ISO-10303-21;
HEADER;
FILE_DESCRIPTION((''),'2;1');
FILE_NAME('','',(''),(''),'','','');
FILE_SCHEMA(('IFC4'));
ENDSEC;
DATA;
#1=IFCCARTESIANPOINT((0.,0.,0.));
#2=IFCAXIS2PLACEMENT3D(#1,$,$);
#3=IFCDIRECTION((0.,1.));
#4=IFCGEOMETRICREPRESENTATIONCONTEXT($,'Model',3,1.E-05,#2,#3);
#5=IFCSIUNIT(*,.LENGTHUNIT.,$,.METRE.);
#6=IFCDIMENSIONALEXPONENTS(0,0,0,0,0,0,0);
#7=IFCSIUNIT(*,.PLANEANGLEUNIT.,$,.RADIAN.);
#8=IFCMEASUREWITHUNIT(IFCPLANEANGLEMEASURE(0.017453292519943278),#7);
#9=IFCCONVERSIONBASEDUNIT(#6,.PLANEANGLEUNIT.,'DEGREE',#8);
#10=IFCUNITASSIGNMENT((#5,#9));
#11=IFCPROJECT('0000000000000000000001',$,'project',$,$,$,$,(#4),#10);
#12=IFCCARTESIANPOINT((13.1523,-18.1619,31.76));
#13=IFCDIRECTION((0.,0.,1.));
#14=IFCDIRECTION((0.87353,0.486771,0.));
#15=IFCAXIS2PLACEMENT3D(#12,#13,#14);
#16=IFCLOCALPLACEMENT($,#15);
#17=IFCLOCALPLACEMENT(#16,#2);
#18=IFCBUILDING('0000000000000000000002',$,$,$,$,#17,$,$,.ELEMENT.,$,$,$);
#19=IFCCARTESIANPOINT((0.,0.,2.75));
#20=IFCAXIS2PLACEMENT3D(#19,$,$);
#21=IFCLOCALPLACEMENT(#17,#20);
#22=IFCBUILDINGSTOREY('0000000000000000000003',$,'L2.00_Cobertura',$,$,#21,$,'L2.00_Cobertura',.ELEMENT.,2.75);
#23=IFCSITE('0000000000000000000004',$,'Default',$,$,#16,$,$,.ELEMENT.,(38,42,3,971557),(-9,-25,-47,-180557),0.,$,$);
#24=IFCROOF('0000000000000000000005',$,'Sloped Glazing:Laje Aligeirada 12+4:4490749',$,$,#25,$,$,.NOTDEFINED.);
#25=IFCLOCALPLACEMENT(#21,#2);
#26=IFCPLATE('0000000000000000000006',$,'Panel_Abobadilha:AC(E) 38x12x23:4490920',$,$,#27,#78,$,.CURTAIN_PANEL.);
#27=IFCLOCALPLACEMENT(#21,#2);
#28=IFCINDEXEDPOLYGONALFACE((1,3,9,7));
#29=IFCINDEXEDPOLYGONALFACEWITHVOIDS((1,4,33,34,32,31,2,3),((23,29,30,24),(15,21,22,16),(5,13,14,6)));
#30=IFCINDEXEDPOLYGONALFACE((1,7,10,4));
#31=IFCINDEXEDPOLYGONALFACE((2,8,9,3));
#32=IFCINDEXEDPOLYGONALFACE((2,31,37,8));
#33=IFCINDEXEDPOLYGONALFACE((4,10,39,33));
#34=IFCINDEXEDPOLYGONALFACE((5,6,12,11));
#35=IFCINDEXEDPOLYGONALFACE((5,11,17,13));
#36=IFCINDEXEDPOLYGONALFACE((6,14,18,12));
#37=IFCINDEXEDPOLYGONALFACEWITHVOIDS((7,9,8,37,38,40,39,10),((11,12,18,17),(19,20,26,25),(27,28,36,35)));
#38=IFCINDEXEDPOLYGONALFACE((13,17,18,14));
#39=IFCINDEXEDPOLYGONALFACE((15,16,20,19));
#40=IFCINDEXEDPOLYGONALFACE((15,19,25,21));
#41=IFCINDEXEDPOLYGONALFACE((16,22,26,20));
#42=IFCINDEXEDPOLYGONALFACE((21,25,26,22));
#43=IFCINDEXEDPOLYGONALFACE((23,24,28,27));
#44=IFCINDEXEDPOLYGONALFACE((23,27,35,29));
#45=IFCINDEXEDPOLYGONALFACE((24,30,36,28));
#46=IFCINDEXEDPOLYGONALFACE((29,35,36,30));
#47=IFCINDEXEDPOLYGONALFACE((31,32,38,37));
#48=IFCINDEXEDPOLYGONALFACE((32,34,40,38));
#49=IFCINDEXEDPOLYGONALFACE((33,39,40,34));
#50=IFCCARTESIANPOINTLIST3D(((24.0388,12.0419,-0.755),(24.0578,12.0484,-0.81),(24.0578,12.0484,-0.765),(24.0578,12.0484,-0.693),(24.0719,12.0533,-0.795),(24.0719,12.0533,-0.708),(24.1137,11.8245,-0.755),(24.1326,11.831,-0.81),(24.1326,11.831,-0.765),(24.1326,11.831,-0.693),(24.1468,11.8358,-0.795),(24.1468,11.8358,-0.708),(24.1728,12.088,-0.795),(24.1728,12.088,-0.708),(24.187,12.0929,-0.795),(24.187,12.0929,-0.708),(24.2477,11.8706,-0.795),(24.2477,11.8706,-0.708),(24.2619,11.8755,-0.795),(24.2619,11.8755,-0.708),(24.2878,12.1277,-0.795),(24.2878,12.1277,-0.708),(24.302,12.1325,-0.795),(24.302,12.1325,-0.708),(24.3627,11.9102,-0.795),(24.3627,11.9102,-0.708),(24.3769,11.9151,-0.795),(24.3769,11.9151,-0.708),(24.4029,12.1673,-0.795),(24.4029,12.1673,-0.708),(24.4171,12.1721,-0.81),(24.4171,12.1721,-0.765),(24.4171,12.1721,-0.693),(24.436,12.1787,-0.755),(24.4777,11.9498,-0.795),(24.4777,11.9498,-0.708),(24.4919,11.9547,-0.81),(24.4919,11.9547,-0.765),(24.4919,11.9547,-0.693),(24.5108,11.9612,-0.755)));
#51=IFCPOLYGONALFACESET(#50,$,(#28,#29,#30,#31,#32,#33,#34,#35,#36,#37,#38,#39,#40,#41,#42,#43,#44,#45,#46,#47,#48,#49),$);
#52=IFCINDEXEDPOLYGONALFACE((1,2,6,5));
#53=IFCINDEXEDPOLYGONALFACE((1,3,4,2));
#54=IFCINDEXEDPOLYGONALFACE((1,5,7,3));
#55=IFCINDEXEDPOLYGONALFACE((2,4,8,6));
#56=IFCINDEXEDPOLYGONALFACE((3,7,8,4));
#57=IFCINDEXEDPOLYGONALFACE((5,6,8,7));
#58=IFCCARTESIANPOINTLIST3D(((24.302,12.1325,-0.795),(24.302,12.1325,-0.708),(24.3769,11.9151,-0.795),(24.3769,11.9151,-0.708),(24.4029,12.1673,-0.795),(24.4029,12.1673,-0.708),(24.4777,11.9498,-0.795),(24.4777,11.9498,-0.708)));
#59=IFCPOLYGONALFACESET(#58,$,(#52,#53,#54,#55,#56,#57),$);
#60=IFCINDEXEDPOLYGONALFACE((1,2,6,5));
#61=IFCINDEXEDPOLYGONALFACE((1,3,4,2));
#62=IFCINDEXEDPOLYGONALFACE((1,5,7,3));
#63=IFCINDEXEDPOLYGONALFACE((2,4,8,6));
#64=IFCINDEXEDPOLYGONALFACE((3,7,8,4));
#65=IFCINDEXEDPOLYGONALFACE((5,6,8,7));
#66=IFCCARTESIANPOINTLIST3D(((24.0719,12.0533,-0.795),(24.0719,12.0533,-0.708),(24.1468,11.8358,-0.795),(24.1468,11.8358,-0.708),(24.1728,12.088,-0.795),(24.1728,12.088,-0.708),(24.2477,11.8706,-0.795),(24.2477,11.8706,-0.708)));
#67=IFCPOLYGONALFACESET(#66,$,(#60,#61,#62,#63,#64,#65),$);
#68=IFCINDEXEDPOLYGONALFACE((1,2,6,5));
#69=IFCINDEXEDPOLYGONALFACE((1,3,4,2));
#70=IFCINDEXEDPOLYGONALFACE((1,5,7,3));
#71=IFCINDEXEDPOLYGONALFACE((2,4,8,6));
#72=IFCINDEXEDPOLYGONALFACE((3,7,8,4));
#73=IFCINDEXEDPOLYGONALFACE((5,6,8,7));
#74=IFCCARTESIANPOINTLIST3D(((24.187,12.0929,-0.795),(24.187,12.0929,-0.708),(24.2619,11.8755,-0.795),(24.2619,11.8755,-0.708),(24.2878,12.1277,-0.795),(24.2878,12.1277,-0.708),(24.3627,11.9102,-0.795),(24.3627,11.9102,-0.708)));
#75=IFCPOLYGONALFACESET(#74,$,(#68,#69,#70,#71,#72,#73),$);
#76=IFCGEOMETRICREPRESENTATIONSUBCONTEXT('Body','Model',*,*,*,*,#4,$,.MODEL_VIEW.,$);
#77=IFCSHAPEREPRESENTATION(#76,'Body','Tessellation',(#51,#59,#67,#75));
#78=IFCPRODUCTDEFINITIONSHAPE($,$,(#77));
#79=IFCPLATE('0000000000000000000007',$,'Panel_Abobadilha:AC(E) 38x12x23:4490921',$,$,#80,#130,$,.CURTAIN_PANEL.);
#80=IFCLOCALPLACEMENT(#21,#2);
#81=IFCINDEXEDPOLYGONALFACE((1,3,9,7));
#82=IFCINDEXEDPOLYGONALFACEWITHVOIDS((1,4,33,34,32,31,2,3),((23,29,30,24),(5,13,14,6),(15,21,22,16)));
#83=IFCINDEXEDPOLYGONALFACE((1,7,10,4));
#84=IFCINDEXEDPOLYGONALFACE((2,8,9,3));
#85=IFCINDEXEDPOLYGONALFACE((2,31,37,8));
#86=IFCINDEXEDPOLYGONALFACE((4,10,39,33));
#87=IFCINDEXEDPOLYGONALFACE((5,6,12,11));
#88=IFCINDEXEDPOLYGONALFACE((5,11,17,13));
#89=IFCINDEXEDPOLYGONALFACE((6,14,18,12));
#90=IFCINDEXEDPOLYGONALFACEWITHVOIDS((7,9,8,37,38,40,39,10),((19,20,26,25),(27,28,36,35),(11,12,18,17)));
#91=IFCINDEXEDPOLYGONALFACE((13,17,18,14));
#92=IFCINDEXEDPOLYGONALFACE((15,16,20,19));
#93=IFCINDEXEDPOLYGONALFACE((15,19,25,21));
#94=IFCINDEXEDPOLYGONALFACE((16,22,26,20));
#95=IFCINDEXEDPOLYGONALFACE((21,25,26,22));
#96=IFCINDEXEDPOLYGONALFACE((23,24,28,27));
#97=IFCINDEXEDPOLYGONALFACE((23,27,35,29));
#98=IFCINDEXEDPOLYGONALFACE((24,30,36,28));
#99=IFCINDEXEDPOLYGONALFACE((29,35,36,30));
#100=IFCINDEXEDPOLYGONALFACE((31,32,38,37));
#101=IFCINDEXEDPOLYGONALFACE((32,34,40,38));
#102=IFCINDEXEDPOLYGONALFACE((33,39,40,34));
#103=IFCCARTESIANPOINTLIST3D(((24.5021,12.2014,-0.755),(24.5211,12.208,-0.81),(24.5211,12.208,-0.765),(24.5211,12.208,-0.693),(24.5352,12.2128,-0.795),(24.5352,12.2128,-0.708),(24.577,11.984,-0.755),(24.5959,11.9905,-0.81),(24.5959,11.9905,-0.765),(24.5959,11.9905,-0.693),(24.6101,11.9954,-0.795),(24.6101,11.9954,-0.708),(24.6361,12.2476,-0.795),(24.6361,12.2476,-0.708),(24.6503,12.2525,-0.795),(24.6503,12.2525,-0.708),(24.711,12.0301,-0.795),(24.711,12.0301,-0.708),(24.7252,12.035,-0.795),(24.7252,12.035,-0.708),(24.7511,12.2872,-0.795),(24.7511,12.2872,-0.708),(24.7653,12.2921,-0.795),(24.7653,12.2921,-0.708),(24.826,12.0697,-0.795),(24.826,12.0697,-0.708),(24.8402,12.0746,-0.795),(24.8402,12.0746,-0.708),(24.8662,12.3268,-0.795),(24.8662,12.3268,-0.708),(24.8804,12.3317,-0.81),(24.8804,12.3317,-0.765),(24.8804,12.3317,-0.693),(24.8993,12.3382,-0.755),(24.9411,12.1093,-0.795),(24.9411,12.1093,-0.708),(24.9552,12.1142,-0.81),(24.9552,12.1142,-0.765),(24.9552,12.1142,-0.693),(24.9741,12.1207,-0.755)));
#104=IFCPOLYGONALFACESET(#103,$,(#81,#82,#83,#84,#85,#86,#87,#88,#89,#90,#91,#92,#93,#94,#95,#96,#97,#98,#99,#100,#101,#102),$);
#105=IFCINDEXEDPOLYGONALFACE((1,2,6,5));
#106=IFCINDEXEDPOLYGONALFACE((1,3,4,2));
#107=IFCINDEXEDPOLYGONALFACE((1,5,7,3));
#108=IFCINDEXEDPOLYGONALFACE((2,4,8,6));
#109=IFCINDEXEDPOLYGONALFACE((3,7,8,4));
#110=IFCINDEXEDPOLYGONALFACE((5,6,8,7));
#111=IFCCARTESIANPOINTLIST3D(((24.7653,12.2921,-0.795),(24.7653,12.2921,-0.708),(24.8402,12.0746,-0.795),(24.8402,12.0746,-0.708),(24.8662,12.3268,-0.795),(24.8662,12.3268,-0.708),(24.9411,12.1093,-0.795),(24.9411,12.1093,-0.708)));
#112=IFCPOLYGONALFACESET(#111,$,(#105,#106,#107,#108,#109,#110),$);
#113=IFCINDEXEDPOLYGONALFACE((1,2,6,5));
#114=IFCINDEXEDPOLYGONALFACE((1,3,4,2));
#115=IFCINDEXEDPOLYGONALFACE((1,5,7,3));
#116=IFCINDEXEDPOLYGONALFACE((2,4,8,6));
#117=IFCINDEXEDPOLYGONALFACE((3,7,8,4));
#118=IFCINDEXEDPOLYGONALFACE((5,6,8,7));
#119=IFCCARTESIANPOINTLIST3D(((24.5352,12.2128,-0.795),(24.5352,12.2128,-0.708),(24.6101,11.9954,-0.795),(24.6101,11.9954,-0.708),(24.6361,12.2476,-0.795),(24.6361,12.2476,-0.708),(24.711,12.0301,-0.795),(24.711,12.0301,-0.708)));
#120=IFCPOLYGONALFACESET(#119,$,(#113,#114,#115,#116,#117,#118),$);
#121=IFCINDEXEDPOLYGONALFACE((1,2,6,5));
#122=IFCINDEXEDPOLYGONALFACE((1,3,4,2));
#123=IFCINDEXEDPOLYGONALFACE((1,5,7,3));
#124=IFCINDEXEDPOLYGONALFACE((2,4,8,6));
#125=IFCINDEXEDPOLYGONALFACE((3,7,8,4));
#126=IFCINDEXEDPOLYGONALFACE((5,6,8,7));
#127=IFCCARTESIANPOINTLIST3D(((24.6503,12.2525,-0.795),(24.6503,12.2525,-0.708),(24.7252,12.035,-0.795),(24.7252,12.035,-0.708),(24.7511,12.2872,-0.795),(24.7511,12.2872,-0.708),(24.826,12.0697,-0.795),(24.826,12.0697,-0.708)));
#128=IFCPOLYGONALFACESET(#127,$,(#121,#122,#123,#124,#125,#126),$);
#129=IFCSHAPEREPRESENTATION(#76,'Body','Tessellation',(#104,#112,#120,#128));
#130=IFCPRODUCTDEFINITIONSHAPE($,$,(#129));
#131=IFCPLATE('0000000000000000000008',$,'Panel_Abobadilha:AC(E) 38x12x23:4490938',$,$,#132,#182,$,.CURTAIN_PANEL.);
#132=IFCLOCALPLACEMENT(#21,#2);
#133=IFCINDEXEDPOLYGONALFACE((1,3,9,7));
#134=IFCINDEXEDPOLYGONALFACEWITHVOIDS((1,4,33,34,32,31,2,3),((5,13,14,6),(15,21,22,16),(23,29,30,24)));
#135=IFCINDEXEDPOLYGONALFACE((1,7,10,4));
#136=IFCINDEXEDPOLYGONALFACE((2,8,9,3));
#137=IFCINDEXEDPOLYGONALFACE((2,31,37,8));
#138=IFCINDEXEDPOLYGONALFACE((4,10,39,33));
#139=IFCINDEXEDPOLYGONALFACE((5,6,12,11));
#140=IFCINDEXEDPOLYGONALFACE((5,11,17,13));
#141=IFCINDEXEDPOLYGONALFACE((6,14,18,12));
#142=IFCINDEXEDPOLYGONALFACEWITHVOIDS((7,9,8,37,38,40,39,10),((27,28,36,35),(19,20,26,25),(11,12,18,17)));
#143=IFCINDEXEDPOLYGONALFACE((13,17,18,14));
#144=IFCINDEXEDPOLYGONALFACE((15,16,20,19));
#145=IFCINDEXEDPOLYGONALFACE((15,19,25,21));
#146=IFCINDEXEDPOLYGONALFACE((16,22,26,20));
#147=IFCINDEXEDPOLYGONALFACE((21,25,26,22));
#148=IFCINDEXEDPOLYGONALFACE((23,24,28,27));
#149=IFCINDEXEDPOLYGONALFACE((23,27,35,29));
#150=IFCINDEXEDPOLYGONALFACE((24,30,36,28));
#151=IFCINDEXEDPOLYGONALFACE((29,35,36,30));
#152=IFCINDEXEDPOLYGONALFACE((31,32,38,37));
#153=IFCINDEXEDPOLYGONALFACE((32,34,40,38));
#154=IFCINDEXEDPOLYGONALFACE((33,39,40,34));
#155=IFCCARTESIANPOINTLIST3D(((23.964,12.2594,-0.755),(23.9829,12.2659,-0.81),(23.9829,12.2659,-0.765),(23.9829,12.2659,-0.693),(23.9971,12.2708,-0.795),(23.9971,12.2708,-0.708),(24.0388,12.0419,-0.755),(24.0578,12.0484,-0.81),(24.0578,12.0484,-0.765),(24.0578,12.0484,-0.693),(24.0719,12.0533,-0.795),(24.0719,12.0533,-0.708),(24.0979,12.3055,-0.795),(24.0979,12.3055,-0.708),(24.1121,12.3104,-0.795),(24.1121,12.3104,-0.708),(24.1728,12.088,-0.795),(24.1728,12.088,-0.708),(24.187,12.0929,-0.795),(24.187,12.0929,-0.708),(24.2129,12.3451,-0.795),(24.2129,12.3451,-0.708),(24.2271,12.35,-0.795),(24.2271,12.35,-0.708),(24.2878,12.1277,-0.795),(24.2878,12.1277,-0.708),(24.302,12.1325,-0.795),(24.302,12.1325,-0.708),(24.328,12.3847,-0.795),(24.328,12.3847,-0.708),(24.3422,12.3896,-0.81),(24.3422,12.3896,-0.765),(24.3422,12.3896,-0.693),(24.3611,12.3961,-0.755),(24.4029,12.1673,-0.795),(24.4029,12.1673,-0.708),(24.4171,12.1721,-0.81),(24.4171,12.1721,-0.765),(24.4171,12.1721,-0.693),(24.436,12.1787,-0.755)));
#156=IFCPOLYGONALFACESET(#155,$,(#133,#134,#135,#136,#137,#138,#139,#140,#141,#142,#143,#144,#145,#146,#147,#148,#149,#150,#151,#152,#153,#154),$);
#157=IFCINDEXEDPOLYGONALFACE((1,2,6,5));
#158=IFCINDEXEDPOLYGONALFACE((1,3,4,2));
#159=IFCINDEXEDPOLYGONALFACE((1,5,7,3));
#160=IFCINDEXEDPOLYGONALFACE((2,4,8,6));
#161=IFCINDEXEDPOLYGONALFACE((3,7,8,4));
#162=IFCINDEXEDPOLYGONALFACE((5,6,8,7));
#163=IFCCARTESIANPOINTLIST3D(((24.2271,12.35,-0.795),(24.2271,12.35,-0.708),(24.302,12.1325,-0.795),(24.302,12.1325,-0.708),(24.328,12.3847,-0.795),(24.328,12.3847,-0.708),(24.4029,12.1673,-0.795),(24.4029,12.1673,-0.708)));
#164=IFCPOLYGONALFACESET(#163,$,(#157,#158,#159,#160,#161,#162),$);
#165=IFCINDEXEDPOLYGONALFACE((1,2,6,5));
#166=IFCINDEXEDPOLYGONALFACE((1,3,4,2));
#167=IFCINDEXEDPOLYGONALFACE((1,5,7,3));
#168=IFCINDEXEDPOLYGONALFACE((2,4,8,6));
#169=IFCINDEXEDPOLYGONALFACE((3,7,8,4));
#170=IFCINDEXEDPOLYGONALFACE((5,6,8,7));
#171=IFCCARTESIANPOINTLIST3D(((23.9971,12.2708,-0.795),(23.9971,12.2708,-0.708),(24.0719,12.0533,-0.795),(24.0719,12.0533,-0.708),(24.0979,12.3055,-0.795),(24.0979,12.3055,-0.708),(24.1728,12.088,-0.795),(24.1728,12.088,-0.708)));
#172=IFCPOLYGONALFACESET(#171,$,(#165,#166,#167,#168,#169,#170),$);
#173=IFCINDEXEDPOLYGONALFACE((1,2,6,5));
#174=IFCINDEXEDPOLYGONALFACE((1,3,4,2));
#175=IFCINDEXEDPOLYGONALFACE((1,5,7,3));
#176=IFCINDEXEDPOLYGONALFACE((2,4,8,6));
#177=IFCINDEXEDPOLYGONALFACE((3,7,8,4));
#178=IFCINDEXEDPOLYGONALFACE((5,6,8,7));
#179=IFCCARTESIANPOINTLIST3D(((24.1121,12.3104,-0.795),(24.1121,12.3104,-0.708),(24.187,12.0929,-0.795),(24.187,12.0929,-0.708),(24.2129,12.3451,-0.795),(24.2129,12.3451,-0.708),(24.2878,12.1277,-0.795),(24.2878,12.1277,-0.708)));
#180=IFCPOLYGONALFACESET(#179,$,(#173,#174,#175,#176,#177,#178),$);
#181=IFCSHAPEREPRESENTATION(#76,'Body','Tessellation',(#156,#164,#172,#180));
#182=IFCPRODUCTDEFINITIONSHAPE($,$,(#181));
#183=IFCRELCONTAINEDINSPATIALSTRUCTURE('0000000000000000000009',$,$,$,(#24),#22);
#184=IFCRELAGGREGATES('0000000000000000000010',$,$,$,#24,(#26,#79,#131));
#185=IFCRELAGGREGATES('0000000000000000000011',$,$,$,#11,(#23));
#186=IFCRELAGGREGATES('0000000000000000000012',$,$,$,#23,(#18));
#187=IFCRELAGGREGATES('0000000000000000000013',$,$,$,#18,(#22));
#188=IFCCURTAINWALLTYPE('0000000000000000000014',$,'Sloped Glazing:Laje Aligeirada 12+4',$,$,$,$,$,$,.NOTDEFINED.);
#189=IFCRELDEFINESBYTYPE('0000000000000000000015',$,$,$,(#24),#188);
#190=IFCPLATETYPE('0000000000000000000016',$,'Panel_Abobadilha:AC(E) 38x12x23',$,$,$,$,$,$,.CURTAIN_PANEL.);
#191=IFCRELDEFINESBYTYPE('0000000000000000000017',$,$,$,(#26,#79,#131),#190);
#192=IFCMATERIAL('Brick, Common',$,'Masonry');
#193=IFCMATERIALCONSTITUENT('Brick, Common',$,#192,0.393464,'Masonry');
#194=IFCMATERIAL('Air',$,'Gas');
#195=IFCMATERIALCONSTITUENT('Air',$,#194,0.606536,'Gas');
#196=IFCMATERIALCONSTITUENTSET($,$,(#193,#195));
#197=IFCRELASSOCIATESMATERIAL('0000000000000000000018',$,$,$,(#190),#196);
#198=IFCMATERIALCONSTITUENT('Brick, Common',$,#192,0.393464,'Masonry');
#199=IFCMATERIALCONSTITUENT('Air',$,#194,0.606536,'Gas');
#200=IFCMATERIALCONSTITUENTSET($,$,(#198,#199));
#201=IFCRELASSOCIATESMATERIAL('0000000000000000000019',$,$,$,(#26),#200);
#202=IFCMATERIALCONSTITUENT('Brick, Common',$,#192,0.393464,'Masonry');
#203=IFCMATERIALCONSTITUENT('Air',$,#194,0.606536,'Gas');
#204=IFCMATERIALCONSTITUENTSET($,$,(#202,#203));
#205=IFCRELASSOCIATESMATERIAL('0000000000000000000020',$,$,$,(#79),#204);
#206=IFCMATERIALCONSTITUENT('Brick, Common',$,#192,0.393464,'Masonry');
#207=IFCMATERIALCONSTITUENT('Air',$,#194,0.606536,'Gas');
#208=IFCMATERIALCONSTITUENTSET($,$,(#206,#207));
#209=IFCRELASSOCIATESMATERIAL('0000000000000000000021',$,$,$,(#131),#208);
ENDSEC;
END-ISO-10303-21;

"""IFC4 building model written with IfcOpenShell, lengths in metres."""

from ifc_helpers import new_model, entity, si_unit, converted_unit, direction, frame, origin, place, context, subcontext, project, spatial, indexed_curve, outline, extrude, source, transform, mapped, material, constituent, constituent_set, type_object, type_shapes, element, aggregate, save


model = new_model("IFC4")

# Units and contexts
model_context = context("Model", 3, precision=1e-05, world=origin(), true_north=direction((0.0, 1.0)))
body_context = subcontext(model_context, "Body", "Model", "MODEL_VIEW")
ifc_project = project(units=[si_unit("LENGTHUNIT", "METRE"), converted_unit("PLANEANGLEUNIT", "DEGREE", entity("IfcPlaneAngleMeasure", 0.017453292519943278), si_unit("PLANEANGLEUNIT", "RADIAN"), dimensions=[0, 0, 0, 0, 0, 0, 0])], contexts=[model_context])

# Site, building, storey
site_placement = place(None, frame((13.1523, -18.1619, 31.76), z_axis=(0.0, 0.0, 1.0), x_axis=(0.87353, 0.486771, 0.0)))
site = spatial("IfcSite", under=ifc_project, at=site_placement, Name="Default", CompositionType="ELEMENT", RefLatitude=(38, 42, 3, 971557), RefLongitude=(-9, -25, -47, -180557), RefElevation=0.0)
building_placement = place(site_placement, origin())
building = spatial("IfcBuilding", under=site, at=building_placement, CompositionType="ELEMENT")
storey_placement = place(building_placement, frame((0.0, 0.0, 2.75)))
storey = spatial("IfcBuildingStorey", under=building, at=storey_placement, Name="L2.00_Cobertura", LongName="L2.00_Cobertura", CompositionType="ELEMENT", Elevation=2.75)

# Roof, plates
curtain_wall_type = type_object("IfcCurtainWallType", Name="Sloped Glazing:Laje Aligeirada 12+4", PredefinedType="NOTDEFINED")
roof_placement = place(storey_placement, frame((0.0, 0.0, -2.75)))
roof = element("IfcRoof", 1, at=roof_placement, inside=storey, type_object=curtain_wall_type, Name="Sloped Glazing:Laje Aligeirada 12+4:4490749", PredefinedType="NOTDEFINED")
ifc_material_1 = material(Name="Brick, Common", Category="Masonry")
ifc_constituent_1 = constituent(ifc_material_1, Name="Brick, Common", Category="Masonry", fraction=0.393464)
ifc_material_2 = material(Name="Air", Category="Gas")
ifc_constituent_2 = constituent(ifc_material_2, Name="Air", Category="Gas", fraction=0.606536)
ifc_constituent_set_1 = constituent_set(constituents=[ifc_constituent_1, ifc_constituent_2])
ifc_constituent_3 = constituent(ifc_material_1, Name="Brick, Common", Category="Masonry", fraction=0.393464)
ifc_constituent_4 = constituent(ifc_material_2, Name="Air", Category="Gas", fraction=0.606536)
ifc_constituent_set_2 = constituent_set(constituents=[ifc_constituent_3, ifc_constituent_4])
plate_type = type_object("IfcPlateType", Name="Panel_Abobadilha:AC(E) 38x12x23", PredefinedType="CURTAIN_PANEL", material=ifc_constituent_set_2)
shared_shape_1 = source(origin(), body_context, "Body", "SweptSolid", [
    extrude(outline(indexed_curve([(-0.19, -0.0543), (0.19, -0.0543), (0.19, -0.0093), (0.21, 0.0007), (0.19, 0.0628), (-0.19, 0.0628), (-0.21, 0.0007), (-0.19, -0.0093), (-0.19, -0.0543)], self_intersect=False), holes=[indexed_curve([(-0.0683, 0.0477), (-0.0683, -0.0393), (-0.175, -0.0393), (-0.175, 0.0477), (-0.0683, 0.0477)], self_intersect=False), indexed_curve([(0.0533, 0.0477), (0.0533, -0.0393), (-0.0533, -0.0393), (-0.0533, 0.0477), (0.0533, 0.0477)], self_intersect=False), indexed_curve([(0.175, 0.0477), (0.175, -0.0393), (0.0683, -0.0393), (0.0683, 0.0477), (0.175, 0.0477)], self_intersect=False)]), frame((0.0, 0.0543, 0.0)), (0.0, 0.0, 1.0), 0.23),
    extrude(outline(indexed_curve([(-0.0533, -0.0435), (0.0533, -0.0435), (0.0533, 0.0435), (-0.0533, 0.0435), (-0.0533, -0.0435)], self_intersect=False)), frame((0.1217, 0.0585, 0.0), z_axis=(0.0, 0.0, 1.0), x_axis=(-1.0, 0.0, 0.0)), (0.0, 0.0, 1.0), 0.23),
    extrude(outline(indexed_curve([(-0.0533, -0.0435), (0.0533, -0.0435), (0.0533, 0.0435), (-0.0533, 0.0435), (-0.0533, -0.0435)], self_intersect=False)), frame((-0.1217, 0.0585, 0.0), z_axis=(0.0, 0.0, 1.0), x_axis=(-1.0, 0.0, 0.0)), (0.0, 0.0, 1.0), 0.23),
    extrude(outline(indexed_curve([(-0.0533, -0.0435), (0.0533, -0.0435), (0.0533, 0.0435), (-0.0533, 0.0435), (-0.0533, -0.0435)], self_intersect=False)), frame((0.0, 0.0585, 0.0), z_axis=(0.0, 0.0, 1.0), x_axis=(-1.0, 0.0, 0.0)), (0.0, 0.0, 1.0), 0.23),
])
type_shapes(plate_type, [shared_shape_1])
plate_1_placement = place(roof_placement, frame((24.2374, 12.1103, 1.94), z_axis=(0.325568, -0.945519, 0.0), x_axis=(0.945519, 0.325568, 0.0)))
plate_1 = element("IfcPlate", 2, at=plate_1_placement, type_object=plate_type, material=ifc_constituent_set_1, Name="Panel_Abobadilha:AC(E) 38x12x23:4490920", PredefinedType="CURTAIN_PANEL", context=body_context, shape_type="MappedRepresentation", body=[
    mapped(shared_shape_1, transform((0.0, 0.0, 0.0), scale=1.0)),
])
ifc_constituent_5 = constituent(ifc_material_1, Name="Brick, Common", Category="Masonry", fraction=0.393464)
ifc_constituent_6 = constituent(ifc_material_2, Name="Air", Category="Gas", fraction=0.606536)
ifc_constituent_set_3 = constituent_set(constituents=[ifc_constituent_5, ifc_constituent_6])
plate_2_placement = place(roof_placement, frame((24.7007, 12.2698, 1.94), z_axis=(0.325568, -0.945519, 0.0), x_axis=(0.945519, 0.325568, 0.0)))
plate_2 = element("IfcPlate", 3, at=plate_2_placement, type_object=plate_type, material=ifc_constituent_set_3, Name="Panel_Abobadilha:AC(E) 38x12x23:4490921", PredefinedType="CURTAIN_PANEL", context=body_context, shape_type="MappedRepresentation", body=[
    mapped(shared_shape_1, transform((0.0, 0.0, 0.0), scale=1.0)),
])
ifc_constituent_7 = constituent(ifc_material_1, Name="Brick, Common", Category="Masonry", fraction=0.393464)
ifc_constituent_8 = constituent(ifc_material_2, Name="Air", Category="Gas", fraction=0.606536)
ifc_constituent_set_4 = constituent_set(constituents=[ifc_constituent_7, ifc_constituent_8])
plate_3_placement = place(roof_placement, frame((24.1625, 12.3278, 1.94), z_axis=(0.325568, -0.945519, 0.0), x_axis=(0.945519, 0.325568, 0.0)))
plate_3 = element("IfcPlate", 4, at=plate_3_placement, type_object=plate_type, material=ifc_constituent_set_4, Name="Panel_Abobadilha:AC(E) 38x12x23:4490938", PredefinedType="CURTAIN_PANEL", context=body_context, shape_type="MappedRepresentation", body=[
    mapped(shared_shape_1, transform((0.0, 0.0, 0.0), scale=1.0)),
])
aggregate(roof, [plate_1, plate_2, plate_3])

save(model, "model.ifc")
